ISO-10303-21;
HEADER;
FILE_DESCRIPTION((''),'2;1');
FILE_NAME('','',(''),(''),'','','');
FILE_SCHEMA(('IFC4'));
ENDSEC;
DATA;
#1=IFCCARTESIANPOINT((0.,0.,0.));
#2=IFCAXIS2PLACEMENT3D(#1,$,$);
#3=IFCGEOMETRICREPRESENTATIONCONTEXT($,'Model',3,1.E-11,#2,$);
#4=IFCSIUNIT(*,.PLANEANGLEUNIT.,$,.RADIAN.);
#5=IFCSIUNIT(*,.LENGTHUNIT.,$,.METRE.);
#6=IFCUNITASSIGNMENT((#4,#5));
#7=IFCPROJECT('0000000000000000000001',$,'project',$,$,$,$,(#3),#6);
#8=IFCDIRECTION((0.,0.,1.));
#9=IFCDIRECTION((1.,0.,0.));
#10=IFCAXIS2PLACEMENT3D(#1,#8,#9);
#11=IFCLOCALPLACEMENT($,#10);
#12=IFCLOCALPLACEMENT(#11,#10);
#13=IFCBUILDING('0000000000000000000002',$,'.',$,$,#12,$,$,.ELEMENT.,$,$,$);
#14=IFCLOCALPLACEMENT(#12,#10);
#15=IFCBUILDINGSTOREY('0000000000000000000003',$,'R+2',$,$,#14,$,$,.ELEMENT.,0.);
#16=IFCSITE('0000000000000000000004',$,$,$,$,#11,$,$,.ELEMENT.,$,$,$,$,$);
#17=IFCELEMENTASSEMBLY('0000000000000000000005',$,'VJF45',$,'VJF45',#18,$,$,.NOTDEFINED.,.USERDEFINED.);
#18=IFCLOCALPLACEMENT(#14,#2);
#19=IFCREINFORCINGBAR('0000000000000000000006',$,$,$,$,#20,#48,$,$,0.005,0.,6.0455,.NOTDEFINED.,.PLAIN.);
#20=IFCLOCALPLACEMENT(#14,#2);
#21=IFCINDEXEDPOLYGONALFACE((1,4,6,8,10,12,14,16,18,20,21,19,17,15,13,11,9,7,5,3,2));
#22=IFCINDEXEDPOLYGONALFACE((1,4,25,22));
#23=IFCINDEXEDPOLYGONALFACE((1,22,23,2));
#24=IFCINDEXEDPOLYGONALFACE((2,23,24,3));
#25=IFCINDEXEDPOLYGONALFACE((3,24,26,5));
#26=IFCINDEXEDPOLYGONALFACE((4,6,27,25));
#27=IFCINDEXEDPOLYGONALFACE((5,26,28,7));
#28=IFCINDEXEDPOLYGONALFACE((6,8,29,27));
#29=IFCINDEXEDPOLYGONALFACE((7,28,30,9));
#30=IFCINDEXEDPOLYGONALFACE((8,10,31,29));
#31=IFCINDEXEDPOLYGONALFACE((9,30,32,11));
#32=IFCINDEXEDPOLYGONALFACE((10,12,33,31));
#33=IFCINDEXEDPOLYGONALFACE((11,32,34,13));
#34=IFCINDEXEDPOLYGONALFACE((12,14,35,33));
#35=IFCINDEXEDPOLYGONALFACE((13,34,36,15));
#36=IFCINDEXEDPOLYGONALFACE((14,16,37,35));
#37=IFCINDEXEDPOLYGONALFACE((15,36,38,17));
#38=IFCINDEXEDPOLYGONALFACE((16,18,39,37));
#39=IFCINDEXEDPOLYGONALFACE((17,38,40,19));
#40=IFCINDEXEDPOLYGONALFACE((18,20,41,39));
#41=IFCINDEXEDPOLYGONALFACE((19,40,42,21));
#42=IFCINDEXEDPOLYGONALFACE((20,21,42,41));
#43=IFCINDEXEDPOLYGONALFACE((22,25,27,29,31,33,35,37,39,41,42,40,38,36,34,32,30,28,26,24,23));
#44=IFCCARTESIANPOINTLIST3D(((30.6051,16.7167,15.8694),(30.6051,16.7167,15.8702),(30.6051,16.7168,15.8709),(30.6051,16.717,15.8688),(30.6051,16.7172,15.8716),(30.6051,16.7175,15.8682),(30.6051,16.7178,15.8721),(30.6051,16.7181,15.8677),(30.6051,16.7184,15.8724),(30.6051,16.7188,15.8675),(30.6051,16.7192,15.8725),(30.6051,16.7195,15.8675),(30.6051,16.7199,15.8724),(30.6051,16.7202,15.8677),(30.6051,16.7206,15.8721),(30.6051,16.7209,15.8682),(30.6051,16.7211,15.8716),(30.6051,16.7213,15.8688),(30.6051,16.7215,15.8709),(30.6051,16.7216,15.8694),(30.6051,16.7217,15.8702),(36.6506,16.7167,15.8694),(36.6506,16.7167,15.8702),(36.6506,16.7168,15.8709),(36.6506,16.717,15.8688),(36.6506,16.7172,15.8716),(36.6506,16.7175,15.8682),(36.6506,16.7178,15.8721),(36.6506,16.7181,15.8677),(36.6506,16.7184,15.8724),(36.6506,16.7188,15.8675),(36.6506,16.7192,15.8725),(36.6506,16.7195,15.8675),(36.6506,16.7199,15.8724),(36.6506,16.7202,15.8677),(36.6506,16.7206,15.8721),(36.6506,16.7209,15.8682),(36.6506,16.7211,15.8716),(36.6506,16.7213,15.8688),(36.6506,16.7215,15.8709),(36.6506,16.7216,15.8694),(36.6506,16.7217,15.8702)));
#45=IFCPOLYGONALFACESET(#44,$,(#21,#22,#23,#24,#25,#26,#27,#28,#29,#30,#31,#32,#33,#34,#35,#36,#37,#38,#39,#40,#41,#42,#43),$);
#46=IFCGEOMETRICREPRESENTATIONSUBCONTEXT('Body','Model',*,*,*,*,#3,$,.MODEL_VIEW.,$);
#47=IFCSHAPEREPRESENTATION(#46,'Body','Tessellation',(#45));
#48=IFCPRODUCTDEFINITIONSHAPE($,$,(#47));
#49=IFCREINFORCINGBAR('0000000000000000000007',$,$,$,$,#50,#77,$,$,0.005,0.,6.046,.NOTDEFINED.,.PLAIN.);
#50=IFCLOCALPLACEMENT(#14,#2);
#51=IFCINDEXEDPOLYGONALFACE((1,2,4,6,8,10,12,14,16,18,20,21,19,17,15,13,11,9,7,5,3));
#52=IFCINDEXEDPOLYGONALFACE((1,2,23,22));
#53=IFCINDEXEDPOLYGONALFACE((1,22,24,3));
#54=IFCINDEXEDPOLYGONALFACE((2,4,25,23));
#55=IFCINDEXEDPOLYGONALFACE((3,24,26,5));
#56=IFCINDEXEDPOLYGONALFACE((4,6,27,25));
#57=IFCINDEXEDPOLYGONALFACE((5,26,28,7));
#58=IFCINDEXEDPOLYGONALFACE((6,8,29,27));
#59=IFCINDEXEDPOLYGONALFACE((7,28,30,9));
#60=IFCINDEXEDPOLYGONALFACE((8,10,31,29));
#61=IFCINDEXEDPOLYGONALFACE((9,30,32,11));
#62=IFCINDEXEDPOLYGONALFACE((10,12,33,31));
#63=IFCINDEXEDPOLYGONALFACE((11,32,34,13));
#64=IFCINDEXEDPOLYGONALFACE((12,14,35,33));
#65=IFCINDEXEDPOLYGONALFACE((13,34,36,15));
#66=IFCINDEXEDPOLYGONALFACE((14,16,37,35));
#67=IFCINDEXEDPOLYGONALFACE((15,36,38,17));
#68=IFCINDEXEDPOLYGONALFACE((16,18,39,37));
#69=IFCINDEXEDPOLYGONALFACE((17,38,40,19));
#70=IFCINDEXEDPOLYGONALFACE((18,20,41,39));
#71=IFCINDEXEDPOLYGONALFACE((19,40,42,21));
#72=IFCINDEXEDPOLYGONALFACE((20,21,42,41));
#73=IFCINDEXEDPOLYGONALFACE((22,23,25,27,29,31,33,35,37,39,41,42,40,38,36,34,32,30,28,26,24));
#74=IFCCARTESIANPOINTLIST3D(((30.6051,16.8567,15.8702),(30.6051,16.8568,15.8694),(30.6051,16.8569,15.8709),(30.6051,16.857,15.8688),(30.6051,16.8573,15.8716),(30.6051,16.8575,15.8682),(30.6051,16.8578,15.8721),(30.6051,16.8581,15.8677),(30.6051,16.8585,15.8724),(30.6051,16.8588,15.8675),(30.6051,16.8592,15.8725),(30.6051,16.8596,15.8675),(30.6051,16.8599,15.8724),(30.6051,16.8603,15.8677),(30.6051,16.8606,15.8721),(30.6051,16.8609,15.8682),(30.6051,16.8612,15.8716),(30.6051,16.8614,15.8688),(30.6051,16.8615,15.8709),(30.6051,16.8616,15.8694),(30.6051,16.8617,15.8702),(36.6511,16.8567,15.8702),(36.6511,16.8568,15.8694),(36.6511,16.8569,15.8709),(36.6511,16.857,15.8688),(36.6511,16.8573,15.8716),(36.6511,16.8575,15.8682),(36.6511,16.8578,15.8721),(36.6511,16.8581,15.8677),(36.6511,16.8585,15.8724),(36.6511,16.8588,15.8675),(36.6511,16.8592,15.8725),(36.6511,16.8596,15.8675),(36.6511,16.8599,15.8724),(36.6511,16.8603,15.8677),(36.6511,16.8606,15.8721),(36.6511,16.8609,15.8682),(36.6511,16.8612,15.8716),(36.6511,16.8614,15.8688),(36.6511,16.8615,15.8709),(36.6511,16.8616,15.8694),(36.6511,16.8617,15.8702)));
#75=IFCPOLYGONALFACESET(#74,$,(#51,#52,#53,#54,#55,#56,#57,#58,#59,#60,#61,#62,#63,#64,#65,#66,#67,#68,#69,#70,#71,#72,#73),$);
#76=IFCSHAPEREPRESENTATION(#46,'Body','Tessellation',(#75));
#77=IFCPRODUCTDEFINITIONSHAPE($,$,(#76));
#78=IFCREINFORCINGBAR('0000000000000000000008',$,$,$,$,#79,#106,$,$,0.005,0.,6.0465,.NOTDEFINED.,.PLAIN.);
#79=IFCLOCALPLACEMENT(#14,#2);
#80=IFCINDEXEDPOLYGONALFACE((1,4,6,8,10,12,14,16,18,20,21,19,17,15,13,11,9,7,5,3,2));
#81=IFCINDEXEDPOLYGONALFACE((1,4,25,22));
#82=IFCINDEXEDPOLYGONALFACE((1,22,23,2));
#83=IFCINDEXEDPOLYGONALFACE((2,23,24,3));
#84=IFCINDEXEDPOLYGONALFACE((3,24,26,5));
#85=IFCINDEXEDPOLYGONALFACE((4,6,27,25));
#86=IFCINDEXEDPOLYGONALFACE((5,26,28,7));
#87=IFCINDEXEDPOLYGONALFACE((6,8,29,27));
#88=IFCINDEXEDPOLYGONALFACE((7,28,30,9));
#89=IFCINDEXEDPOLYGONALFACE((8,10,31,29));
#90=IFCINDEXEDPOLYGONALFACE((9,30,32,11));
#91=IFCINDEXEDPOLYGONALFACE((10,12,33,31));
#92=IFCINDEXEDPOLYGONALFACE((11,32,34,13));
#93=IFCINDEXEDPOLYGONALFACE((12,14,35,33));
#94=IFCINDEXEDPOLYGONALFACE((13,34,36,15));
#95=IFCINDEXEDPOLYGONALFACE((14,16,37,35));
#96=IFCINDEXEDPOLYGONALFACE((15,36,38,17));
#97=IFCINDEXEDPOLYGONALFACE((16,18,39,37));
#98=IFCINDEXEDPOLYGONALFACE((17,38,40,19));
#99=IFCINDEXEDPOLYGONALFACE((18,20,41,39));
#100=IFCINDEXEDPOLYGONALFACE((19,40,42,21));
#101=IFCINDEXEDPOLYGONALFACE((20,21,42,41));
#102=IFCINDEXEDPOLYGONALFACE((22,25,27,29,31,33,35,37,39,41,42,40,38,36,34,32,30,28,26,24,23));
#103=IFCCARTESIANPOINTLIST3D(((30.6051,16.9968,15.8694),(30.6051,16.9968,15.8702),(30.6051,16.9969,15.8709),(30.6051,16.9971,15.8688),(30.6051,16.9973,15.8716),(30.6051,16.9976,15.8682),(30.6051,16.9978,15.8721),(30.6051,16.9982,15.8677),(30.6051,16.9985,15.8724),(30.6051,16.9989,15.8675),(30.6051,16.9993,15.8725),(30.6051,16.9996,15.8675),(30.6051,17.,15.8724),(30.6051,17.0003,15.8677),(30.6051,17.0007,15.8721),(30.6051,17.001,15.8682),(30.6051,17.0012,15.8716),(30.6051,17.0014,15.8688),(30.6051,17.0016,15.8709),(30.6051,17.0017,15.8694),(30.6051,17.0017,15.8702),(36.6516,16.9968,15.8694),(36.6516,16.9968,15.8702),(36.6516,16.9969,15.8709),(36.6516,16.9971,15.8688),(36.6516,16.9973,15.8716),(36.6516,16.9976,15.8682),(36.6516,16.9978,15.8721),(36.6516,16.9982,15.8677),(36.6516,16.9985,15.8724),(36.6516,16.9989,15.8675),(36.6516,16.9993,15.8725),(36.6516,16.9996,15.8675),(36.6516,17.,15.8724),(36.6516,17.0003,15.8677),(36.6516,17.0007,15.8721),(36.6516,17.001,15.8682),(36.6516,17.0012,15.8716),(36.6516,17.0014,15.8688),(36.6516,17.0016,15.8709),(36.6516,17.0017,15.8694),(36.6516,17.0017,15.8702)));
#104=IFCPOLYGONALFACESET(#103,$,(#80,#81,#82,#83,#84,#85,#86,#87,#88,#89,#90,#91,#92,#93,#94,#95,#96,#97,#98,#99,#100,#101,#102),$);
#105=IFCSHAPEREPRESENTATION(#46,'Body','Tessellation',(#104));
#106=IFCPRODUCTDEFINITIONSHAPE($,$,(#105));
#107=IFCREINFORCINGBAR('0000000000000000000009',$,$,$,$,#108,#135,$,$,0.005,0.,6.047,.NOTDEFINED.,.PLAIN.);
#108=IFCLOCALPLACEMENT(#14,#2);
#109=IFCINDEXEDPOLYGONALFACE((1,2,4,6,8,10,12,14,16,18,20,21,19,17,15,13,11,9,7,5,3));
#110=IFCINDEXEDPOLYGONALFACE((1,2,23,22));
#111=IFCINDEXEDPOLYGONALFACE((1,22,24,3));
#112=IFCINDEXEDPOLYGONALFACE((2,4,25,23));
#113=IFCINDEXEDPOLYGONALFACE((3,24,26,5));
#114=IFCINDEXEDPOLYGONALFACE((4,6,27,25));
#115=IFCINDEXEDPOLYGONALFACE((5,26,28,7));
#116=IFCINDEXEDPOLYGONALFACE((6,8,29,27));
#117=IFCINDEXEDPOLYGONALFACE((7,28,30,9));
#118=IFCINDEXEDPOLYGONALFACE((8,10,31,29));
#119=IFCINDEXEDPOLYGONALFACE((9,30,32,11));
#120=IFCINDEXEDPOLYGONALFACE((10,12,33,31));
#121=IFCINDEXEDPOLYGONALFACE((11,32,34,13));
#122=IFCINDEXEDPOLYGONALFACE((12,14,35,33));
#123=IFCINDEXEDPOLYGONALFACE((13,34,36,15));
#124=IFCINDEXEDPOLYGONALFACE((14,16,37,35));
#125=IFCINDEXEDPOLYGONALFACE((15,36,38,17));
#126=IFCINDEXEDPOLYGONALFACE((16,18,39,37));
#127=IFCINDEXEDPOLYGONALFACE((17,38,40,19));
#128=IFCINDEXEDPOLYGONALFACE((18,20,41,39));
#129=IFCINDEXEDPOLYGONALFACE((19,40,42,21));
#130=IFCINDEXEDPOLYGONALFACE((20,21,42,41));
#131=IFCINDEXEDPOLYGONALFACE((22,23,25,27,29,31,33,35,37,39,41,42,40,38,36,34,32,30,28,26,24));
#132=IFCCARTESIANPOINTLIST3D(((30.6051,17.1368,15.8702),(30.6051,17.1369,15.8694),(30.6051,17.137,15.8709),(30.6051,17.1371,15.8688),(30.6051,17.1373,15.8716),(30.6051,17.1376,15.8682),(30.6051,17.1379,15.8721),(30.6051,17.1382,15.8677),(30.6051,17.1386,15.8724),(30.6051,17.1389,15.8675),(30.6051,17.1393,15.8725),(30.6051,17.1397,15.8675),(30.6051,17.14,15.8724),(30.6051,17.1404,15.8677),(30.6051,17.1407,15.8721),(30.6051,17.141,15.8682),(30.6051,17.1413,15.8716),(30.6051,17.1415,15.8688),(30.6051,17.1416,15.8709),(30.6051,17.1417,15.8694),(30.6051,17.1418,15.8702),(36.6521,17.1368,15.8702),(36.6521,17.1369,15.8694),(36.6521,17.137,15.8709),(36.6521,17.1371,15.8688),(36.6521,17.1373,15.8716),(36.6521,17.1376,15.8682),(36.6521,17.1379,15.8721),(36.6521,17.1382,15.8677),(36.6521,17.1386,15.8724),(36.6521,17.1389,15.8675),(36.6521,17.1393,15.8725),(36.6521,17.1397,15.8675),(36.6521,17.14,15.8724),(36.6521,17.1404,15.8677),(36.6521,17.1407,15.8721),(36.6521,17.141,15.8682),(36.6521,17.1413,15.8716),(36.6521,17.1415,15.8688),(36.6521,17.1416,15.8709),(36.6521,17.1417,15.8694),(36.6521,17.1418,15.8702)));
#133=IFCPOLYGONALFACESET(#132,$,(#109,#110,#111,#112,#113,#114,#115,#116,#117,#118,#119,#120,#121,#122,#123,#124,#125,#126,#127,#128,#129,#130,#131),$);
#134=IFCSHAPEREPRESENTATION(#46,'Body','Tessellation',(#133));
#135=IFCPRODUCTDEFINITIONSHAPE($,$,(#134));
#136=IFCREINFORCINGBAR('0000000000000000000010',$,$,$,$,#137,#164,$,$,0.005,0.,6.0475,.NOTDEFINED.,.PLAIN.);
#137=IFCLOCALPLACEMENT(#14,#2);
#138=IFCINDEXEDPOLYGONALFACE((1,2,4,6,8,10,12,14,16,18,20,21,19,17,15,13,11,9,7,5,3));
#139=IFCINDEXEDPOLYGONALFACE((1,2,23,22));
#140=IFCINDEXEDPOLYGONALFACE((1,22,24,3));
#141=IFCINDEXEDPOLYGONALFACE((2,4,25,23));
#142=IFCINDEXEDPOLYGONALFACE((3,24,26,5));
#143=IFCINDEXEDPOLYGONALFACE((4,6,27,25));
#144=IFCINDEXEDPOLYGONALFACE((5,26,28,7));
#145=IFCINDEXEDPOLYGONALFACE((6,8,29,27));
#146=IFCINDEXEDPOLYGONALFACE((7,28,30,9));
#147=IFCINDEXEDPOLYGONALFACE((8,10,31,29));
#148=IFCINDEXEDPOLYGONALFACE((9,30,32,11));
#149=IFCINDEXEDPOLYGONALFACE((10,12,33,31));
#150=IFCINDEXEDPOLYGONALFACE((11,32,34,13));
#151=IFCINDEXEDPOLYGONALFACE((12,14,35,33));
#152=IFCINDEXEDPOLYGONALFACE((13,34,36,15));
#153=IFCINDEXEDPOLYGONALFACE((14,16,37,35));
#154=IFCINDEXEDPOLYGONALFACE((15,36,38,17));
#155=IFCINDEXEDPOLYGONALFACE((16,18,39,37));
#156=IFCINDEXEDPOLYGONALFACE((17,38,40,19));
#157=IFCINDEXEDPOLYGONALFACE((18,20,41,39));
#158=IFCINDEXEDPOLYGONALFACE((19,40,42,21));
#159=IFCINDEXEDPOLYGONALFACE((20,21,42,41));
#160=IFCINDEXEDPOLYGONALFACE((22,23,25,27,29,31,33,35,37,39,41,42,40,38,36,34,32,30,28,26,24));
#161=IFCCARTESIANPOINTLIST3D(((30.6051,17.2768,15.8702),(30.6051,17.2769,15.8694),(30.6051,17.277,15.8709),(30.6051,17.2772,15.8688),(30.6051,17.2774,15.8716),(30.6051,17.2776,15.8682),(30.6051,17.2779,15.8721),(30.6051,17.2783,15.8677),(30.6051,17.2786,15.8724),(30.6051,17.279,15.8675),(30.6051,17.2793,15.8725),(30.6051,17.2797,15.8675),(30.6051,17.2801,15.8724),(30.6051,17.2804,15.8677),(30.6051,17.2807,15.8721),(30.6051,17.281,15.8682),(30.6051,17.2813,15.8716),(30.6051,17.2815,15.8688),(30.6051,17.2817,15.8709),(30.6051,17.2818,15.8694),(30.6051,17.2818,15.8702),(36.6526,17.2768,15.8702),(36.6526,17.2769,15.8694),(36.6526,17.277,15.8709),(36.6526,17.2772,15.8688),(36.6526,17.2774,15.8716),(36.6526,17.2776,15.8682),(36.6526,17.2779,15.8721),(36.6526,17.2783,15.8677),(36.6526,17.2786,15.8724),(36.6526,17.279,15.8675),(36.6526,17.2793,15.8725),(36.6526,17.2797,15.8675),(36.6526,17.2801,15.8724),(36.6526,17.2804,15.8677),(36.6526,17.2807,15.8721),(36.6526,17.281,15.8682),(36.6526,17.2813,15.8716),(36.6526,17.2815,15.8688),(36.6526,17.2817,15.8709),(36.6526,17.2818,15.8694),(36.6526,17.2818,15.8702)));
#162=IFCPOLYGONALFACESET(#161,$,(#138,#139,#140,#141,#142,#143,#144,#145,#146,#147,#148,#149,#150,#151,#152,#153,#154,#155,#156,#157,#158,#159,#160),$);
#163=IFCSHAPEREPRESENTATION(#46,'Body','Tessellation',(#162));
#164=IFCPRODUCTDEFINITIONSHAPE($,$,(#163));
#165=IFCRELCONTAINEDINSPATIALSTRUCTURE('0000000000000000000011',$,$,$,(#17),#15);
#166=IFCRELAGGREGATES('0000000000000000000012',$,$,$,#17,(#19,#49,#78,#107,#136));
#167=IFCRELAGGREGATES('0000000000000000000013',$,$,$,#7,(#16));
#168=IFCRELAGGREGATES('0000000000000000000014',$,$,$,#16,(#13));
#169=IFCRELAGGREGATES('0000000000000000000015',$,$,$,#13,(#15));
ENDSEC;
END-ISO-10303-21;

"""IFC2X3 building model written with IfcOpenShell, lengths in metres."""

from ifc_helpers import new_model, entity, si_unit, origin, origin_with_axes, place, context, subcontext, project, spatial, shape, element, aggregate, save


model = new_model("IFC2X3")

# Units and contexts
model_context = context("Model", 3, precision=1e-11, world=origin())
body_context = subcontext(model_context, "Body", "Model", "MODEL_VIEW")
ifc_project = project(units=[si_unit("PLANEANGLEUNIT", "RADIAN"), si_unit("LENGTHUNIT", "METRE")], contexts=[model_context])

# Site, building, storey
site_placement = place(None, origin_with_axes())
site = spatial("IfcSite", under=ifc_project, at=site_placement, CompositionType="ELEMENT")
building_placement = place(site_placement, origin_with_axes())
building = spatial("IfcBuilding", under=site, at=building_placement, Name=".", CompositionType="ELEMENT")
storey_placement = place(building_placement, origin_with_axes())
storey = spatial("IfcBuildingStorey", under=building, at=storey_placement, Name="R+2", CompositionType="ELEMENT", Elevation=0.0)

# Element assembly, reinforcing bars
assembly_1_placement = place(storey_placement, origin_with_axes())
assembly_1 = element("IfcElementAssembly", 1, at=assembly_1_placement, inside=storey, Name="VJF45", ObjectType="VJF45", AssemblyPlace="NOTDEFINED", PredefinedType="USERDEFINED")
reinforcing_bar_1_placement = place(assembly_1_placement, origin_with_axes())
reinforcing_bar_1 = element("IfcReinforcingBar", 2, at=reinforcing_bar_1_placement, BarLength=6.0455, BarRole="NOTDEFINED", BarSurface="PLAIN", CrossSectionArea=0.0, NominalDiameter=0.005, shapes=[
    shape(body_context, "Body", "AdvancedSweptSolid", [entity("IfcSweptDiskSolid", entity("IfcPolyline", [entity("IfcCartesianPoint", [30.6051, 16.7192, 15.87]), entity("IfcCartesianPoint", [36.6506, 16.7192, 15.87])]), 0.0025, None, 0.0, 6.0455)]),
    shape(body_context, "Body", "AdvancedSweptSolid", [entity("IfcSweptDiskSolid", entity("IfcPolyline", [entity("IfcCartesianPoint", [30.6051, 16.7192, 15.87]), entity("IfcCartesianPoint", [36.6506, 16.7192, 15.87])]), 0.0025, None, 0.0, 6.0455)]),
])
reinforcing_bar_2_placement = place(assembly_1_placement, origin_with_axes())
reinforcing_bar_2 = element("IfcReinforcingBar", 3, at=reinforcing_bar_2_placement, BarLength=6.046, BarRole="NOTDEFINED", BarSurface="PLAIN", CrossSectionArea=0.0, NominalDiameter=0.005, shapes=[
    shape(body_context, "Body", "AdvancedSweptSolid", [entity("IfcSweptDiskSolid", entity("IfcPolyline", [entity("IfcCartesianPoint", [30.6051, 16.8592, 15.87]), entity("IfcCartesianPoint", [36.6511, 16.8592, 15.87])]), 0.0025, None, 0.0, 6.046)]),
    shape(body_context, "Body", "AdvancedSweptSolid", [entity("IfcSweptDiskSolid", entity("IfcPolyline", [entity("IfcCartesianPoint", [30.6051, 16.8592, 15.87]), entity("IfcCartesianPoint", [36.6511, 16.8592, 15.87])]), 0.0025, None, 0.0, 6.046)]),
])
reinforcing_bar_3_placement = place(assembly_1_placement, origin_with_axes())
reinforcing_bar_3 = element("IfcReinforcingBar", 4, at=reinforcing_bar_3_placement, BarLength=6.0465, BarRole="NOTDEFINED", BarSurface="PLAIN", CrossSectionArea=0.0, NominalDiameter=0.005, shapes=[
    shape(body_context, "Body", "AdvancedSweptSolid", [entity("IfcSweptDiskSolid", entity("IfcPolyline", [entity("IfcCartesianPoint", [30.6051, 16.9993, 15.87]), entity("IfcCartesianPoint", [36.6516, 16.9993, 15.87])]), 0.0025, None, 0.0, 6.0465)]),
    shape(body_context, "Body", "AdvancedSweptSolid", [entity("IfcSweptDiskSolid", entity("IfcPolyline", [entity("IfcCartesianPoint", [30.6051, 16.9993, 15.87]), entity("IfcCartesianPoint", [36.6516, 16.9993, 15.87])]), 0.0025, None, 0.0, 6.0465)]),
])
reinforcing_bar_4_placement = place(assembly_1_placement, origin_with_axes())
reinforcing_bar_4 = element("IfcReinforcingBar", 5, at=reinforcing_bar_4_placement, BarLength=6.047, BarRole="NOTDEFINED", BarSurface="PLAIN", CrossSectionArea=0.0, NominalDiameter=0.005, shapes=[
    shape(body_context, "Body", "AdvancedSweptSolid", [entity("IfcSweptDiskSolid", entity("IfcPolyline", [entity("IfcCartesianPoint", [30.6051, 17.1393, 15.87]), entity("IfcCartesianPoint", [36.6521, 17.1393, 15.87])]), 0.0025, None, 0.0, 6.047)]),
    shape(body_context, "Body", "AdvancedSweptSolid", [entity("IfcSweptDiskSolid", entity("IfcPolyline", [entity("IfcCartesianPoint", [30.6051, 17.1393, 15.87]), entity("IfcCartesianPoint", [36.6521, 17.1393, 15.87])]), 0.0025, None, 0.0, 6.047)]),
])
reinforcing_bar_5_placement = place(assembly_1_placement, origin_with_axes())
reinforcing_bar_5 = element("IfcReinforcingBar", 6, at=reinforcing_bar_5_placement, BarLength=6.0475, BarRole="NOTDEFINED", BarSurface="PLAIN", CrossSectionArea=0.0, NominalDiameter=0.005, shapes=[
    shape(body_context, "Body", "AdvancedSweptSolid", [entity("IfcSweptDiskSolid", entity("IfcPolyline", [entity("IfcCartesianPoint", [30.6051, 17.2793, 15.87]), entity("IfcCartesianPoint", [36.6526, 17.2793, 15.87])]), 0.0025, None, 0.0, 6.0475)]),
    shape(body_context, "Body", "AdvancedSweptSolid", [entity("IfcSweptDiskSolid", entity("IfcPolyline", [entity("IfcCartesianPoint", [30.6051, 17.2793, 15.87]), entity("IfcCartesianPoint", [36.6526, 17.2793, 15.87])]), 0.0025, None, 0.0, 6.0475)]),
])
aggregate(assembly_1, [reinforcing_bar_1, reinforcing_bar_2, reinforcing_bar_3, reinforcing_bar_4, reinforcing_bar_5])

save(model, "model.ifc")
